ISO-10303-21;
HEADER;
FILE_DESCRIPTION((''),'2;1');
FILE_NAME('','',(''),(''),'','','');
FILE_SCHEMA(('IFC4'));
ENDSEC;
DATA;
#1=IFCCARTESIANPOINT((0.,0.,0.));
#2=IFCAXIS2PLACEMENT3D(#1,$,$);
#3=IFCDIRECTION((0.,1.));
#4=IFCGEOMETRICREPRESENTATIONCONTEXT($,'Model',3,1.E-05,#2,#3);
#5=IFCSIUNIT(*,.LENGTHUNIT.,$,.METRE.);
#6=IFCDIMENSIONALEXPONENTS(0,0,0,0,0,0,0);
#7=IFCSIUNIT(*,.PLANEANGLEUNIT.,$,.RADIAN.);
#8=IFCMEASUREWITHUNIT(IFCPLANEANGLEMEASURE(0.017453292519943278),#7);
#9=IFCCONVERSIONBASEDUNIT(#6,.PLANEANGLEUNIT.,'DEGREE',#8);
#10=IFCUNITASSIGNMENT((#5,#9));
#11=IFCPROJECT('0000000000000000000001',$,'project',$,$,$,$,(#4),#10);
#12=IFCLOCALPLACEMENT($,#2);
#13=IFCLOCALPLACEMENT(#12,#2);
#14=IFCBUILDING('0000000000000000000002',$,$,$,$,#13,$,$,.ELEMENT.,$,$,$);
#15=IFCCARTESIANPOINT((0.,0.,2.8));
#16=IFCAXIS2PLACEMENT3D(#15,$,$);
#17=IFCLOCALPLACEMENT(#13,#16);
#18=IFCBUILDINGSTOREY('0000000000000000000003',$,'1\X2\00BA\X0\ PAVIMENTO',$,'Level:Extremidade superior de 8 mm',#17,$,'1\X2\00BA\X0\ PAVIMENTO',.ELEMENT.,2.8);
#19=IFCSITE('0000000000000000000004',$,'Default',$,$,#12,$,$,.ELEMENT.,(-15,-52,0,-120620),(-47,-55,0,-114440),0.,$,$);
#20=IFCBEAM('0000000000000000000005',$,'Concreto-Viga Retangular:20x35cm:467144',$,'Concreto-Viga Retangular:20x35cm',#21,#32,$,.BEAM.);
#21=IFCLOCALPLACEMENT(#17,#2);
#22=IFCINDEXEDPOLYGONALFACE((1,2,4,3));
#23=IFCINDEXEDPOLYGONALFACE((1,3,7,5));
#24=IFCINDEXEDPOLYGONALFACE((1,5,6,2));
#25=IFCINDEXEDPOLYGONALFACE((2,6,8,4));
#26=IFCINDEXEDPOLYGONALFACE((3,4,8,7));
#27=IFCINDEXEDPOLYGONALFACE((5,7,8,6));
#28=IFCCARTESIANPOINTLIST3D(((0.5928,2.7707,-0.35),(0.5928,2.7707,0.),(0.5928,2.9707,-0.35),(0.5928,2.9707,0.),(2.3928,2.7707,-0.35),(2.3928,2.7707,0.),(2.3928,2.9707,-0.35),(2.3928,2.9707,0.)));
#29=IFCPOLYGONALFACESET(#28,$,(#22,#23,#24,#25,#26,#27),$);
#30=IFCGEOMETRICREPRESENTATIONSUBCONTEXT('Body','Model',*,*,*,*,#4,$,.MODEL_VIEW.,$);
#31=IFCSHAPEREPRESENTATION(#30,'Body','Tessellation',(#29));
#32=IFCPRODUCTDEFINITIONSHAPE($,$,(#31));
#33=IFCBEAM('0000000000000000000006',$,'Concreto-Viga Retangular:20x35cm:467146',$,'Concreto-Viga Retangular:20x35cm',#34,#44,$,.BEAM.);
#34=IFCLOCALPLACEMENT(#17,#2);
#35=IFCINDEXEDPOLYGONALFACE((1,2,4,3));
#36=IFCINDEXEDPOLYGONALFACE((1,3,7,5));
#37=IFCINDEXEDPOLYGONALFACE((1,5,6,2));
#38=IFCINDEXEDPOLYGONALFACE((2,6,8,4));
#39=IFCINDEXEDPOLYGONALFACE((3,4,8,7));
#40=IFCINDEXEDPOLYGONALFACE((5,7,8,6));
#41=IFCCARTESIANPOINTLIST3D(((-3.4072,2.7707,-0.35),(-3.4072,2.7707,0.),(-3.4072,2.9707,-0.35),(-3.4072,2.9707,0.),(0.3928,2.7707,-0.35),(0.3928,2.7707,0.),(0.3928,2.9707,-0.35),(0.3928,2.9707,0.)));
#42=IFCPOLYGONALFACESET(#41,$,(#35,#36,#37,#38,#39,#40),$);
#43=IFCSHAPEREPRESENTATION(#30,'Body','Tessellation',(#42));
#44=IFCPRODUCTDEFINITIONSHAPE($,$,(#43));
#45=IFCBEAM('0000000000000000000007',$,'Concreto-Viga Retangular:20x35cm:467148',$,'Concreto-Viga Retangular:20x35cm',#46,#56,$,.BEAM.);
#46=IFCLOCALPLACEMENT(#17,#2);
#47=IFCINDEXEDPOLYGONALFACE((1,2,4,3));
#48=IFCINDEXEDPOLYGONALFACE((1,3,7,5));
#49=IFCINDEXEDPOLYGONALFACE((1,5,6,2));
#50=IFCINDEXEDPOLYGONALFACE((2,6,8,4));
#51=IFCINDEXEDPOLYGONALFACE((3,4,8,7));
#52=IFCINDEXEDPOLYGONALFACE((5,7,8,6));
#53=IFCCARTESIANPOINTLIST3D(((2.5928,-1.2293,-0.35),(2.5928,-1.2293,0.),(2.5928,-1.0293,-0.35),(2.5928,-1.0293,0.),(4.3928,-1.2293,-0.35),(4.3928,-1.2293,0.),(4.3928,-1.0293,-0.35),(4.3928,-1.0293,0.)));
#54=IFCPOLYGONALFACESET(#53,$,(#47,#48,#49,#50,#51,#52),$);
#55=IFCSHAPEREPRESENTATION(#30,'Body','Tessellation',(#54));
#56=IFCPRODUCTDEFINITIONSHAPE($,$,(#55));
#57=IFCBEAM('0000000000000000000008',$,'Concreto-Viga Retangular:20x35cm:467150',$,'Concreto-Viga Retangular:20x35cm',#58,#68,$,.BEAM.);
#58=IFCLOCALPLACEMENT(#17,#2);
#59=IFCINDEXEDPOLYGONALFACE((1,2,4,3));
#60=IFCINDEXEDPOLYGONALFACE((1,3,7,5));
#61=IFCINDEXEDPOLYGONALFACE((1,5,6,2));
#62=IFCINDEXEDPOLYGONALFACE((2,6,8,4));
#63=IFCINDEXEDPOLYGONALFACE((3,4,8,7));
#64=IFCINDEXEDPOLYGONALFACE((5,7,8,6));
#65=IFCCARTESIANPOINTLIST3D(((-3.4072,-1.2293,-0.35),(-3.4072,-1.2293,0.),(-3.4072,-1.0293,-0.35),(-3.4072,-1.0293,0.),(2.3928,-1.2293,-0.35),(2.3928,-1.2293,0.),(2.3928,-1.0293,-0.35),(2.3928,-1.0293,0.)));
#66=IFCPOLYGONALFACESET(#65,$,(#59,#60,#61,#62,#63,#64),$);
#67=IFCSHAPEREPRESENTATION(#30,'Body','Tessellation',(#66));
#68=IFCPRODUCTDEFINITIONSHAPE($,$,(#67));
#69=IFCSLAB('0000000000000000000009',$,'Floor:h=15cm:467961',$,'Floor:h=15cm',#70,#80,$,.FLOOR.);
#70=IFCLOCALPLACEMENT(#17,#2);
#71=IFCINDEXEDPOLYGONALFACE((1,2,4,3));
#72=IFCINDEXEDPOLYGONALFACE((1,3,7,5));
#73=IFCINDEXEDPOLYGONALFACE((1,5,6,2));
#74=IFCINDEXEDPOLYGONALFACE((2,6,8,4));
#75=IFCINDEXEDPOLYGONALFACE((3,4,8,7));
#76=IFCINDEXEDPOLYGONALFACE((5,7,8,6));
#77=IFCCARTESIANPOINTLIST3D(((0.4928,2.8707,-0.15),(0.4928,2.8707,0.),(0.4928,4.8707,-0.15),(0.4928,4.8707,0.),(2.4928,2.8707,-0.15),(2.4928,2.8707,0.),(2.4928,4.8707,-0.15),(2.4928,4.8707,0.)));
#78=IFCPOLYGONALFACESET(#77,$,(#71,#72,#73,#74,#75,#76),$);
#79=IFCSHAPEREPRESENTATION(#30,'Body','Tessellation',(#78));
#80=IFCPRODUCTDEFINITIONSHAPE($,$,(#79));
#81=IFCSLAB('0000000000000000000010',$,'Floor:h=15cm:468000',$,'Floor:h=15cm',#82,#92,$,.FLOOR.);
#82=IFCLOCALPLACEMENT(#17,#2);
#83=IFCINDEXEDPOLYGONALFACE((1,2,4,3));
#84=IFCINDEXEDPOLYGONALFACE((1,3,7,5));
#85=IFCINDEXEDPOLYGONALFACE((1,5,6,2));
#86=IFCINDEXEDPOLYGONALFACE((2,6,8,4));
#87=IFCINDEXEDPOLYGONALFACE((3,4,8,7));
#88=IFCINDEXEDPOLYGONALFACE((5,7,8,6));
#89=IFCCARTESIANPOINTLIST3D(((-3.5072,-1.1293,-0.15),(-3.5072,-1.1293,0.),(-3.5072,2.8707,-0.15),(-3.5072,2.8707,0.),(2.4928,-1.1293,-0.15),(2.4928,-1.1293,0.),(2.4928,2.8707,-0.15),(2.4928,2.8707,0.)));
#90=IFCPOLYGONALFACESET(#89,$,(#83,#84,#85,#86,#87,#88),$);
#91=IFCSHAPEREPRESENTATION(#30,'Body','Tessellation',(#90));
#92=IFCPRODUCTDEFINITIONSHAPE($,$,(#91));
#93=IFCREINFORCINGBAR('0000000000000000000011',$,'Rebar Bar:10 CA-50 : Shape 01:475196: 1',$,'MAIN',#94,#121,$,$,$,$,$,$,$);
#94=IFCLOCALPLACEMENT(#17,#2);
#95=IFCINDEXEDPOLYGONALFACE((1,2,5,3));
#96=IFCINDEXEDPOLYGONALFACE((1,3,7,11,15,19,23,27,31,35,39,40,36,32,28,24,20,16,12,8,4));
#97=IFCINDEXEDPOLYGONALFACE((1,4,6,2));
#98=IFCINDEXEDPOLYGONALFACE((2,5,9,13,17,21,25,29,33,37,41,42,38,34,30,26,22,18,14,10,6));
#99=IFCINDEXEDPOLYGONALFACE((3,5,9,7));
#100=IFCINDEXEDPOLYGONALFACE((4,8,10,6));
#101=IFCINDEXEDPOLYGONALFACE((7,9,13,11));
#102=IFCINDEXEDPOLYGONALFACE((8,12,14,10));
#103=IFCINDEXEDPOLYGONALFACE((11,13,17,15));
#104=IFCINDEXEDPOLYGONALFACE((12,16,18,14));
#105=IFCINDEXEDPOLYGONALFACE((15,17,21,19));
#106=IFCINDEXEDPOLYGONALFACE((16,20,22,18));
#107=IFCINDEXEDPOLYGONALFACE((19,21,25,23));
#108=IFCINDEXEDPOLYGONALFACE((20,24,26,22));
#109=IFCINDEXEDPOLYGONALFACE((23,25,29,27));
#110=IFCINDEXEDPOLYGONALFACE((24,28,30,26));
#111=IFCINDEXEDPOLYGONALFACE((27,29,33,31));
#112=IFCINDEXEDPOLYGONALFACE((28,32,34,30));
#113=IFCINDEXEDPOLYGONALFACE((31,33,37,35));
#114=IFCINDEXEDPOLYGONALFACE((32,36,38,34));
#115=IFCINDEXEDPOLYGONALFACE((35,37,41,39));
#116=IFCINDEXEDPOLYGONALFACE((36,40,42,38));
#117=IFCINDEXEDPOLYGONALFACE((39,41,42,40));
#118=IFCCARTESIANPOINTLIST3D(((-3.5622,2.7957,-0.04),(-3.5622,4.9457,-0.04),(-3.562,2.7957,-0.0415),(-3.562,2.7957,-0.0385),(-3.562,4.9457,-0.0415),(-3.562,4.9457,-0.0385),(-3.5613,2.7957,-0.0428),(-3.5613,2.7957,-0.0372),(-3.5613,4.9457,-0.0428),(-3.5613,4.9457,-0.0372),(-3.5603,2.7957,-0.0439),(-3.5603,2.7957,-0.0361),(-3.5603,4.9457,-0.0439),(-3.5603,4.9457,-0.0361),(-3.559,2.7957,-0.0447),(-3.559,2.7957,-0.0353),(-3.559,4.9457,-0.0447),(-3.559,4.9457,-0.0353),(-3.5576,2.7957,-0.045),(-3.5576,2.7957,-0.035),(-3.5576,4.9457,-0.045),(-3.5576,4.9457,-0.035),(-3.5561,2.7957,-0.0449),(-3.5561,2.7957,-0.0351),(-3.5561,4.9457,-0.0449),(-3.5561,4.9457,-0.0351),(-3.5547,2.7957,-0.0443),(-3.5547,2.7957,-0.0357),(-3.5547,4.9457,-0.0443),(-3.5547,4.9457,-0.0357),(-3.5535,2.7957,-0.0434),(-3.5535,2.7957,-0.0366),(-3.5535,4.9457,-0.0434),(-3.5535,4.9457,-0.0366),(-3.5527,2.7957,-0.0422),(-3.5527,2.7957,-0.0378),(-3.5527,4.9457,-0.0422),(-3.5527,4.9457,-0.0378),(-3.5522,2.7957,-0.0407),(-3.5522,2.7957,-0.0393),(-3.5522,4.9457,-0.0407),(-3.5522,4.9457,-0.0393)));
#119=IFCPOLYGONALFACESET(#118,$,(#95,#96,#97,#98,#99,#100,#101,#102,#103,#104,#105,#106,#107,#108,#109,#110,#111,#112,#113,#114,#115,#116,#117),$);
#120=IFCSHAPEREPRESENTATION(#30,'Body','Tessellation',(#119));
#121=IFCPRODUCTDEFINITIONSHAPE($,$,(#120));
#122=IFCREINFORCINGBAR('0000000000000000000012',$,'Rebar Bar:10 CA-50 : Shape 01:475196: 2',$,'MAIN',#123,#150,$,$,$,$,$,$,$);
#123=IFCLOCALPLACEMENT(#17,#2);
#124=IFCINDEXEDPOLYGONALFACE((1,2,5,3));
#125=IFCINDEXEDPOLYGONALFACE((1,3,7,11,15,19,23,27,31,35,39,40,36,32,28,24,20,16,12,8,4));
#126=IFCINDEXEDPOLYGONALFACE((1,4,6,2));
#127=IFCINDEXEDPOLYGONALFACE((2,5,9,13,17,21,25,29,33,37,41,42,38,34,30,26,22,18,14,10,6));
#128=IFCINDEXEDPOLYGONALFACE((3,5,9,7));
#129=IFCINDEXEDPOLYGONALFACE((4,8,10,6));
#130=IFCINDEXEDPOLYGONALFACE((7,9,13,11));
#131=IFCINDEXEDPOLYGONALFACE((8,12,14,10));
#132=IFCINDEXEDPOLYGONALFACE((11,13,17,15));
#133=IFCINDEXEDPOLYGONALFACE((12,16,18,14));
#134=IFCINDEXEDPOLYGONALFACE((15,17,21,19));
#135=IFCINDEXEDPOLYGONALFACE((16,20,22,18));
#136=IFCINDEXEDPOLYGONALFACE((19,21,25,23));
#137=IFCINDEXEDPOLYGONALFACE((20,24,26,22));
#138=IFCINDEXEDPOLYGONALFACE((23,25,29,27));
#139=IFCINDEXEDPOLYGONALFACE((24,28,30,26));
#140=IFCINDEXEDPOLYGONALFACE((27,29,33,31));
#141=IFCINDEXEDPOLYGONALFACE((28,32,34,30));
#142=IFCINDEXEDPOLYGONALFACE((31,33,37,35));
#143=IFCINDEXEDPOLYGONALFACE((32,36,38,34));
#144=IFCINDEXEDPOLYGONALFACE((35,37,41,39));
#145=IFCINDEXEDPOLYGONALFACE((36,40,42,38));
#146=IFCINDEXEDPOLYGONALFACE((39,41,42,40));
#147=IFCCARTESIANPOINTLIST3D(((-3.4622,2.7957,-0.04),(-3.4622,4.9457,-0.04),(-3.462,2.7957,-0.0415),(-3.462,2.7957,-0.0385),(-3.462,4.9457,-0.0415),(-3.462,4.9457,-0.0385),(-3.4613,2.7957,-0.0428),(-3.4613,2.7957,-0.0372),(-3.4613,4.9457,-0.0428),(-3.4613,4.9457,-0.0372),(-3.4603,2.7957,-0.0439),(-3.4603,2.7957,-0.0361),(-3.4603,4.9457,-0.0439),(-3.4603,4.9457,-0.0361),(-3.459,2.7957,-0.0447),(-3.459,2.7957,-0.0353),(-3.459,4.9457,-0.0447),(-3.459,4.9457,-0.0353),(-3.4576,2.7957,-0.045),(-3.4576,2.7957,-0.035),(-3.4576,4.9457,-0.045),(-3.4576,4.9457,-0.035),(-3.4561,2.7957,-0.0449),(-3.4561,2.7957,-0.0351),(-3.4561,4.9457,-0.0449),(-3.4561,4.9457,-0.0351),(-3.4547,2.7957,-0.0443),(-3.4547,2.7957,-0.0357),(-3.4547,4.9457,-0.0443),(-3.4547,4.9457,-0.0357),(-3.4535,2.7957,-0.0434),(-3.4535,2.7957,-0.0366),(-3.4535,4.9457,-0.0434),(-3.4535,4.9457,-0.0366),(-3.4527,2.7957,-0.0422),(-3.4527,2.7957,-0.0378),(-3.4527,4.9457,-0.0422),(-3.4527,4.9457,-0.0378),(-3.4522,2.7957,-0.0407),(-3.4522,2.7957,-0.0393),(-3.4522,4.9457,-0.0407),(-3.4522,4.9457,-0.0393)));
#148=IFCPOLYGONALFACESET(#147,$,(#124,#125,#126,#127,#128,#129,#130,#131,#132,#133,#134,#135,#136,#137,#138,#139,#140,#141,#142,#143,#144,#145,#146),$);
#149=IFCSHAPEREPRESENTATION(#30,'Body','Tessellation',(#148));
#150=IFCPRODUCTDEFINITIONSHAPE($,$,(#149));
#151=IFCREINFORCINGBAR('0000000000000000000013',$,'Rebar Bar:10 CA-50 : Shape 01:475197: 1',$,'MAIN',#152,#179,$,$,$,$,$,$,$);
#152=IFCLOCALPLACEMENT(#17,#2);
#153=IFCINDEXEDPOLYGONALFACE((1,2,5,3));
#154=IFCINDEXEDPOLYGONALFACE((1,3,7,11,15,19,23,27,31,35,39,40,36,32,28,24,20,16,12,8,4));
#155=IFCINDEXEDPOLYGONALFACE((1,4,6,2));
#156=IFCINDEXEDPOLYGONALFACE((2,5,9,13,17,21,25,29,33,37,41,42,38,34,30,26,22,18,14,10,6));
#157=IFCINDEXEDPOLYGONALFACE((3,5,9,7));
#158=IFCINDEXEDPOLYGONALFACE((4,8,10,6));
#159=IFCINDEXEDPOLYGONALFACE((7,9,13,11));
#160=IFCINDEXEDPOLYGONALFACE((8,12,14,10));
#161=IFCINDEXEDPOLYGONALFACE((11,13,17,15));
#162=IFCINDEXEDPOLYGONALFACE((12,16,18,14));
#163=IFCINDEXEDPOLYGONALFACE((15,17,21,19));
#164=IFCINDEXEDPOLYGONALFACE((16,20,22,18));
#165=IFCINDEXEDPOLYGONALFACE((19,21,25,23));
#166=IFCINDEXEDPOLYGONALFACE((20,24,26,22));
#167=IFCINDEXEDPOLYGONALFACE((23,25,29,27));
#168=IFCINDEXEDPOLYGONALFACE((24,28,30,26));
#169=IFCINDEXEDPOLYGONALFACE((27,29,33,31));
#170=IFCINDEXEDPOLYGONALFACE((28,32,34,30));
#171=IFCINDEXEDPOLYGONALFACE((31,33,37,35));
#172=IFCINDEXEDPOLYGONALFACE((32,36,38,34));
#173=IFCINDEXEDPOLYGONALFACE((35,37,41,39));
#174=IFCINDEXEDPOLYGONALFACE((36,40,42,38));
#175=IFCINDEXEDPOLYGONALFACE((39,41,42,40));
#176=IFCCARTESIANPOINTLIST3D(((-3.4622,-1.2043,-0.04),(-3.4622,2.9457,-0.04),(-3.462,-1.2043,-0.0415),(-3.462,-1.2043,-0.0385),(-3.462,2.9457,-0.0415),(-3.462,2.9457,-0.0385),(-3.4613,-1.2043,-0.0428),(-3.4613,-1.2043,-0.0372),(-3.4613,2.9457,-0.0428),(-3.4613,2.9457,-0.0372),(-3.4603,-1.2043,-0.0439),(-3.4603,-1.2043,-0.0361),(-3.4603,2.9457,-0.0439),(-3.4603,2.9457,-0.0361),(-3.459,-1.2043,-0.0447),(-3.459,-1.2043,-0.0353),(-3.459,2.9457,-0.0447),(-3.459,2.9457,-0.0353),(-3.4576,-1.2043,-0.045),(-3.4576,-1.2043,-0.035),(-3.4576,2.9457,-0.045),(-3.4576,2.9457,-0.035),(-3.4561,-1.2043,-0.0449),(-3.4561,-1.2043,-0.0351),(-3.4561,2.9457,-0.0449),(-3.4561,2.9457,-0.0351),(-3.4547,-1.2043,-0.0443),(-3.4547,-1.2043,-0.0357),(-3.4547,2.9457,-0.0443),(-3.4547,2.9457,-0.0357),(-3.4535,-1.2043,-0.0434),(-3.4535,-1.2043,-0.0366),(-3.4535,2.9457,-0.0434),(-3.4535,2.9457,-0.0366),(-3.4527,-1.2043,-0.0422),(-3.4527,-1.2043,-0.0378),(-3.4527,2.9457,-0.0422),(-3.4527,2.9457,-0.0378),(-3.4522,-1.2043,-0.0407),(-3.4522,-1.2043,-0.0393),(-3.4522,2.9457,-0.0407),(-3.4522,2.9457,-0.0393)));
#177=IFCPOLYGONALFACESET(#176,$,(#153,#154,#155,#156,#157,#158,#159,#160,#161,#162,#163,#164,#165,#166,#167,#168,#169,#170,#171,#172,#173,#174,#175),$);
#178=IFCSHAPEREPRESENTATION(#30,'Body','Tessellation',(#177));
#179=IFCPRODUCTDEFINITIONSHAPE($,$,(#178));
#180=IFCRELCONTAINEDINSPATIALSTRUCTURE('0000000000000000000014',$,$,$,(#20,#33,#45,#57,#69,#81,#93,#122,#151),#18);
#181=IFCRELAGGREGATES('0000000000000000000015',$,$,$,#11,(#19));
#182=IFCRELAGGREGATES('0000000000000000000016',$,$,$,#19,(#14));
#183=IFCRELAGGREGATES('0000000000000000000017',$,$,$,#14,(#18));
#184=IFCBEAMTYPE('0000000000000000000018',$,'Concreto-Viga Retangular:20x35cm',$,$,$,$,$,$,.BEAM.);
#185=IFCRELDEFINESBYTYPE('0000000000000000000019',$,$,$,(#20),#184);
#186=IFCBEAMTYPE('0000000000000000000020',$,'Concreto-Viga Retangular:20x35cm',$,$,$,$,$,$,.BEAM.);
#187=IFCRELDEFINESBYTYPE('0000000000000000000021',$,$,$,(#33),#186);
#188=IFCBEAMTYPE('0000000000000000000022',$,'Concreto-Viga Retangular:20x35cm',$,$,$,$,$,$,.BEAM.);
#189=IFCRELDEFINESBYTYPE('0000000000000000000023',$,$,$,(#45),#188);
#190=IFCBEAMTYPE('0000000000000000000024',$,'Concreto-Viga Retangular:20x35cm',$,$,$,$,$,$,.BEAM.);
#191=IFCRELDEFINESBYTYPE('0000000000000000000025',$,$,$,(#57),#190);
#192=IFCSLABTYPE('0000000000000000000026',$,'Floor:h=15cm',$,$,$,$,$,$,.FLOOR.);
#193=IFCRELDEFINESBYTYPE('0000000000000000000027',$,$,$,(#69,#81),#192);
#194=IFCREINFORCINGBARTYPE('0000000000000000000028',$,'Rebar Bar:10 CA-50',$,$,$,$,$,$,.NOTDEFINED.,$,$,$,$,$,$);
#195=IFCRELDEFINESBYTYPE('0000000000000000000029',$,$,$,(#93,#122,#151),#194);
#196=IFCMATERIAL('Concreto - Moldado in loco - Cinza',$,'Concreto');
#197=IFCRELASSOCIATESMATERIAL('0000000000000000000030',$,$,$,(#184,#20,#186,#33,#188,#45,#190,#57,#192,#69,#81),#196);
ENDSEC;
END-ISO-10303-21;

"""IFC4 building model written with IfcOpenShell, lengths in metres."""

from ifc_helpers import new_model, entity, si_unit, converted_unit, direction, frame, origin, place, context, subcontext, project, spatial, indexed_curve, outline, extrude, source, transform, mapped, material, type_object, type_shapes, element, save


model = new_model("IFC4")

# Units and contexts
model_context = context("Model", 3, precision=1e-05, world=origin(), true_north=direction((0.0, 1.0)))
body_context = subcontext(model_context, "Body", "Model", "MODEL_VIEW")
ifc_project = project(units=[si_unit("LENGTHUNIT", "METRE"), converted_unit("PLANEANGLEUNIT", "DEGREE", entity("IfcPlaneAngleMeasure", 0.017453292519943278), si_unit("PLANEANGLEUNIT", "RADIAN"), dimensions=[0, 0, 0, 0, 0, 0, 0])], contexts=[model_context])

# Site, building, storey
site_placement = place(None, origin())
site = spatial("IfcSite", under=ifc_project, at=site_placement, Name="Default", CompositionType="ELEMENT", RefLatitude=(-15, -52, 0, -120620), RefLongitude=(-47, -55, 0, -114440), RefElevation=0.0)
building_placement = place(site_placement, origin())
building = spatial("IfcBuilding", under=site, at=building_placement, CompositionType="ELEMENT")
storey_placement = place(building_placement, frame((0.0, 0.0, 2.8)))
storey = spatial("IfcBuildingStorey", under=building, at=storey_placement, Name="1º PAVIMENTO", ObjectType="Level:Extremidade superior de 8 mm", LongName="1º PAVIMENTO", CompositionType="ELEMENT", Elevation=2.8)

# Beams
ifc_material = material(Name="Concreto - Moldado in loco - Cinza", Category="Concreto")
beam_type_1 = type_object("IfcBeamType", Name="Concreto-Viga Retangular:20x35cm", PredefinedType="BEAM", material=ifc_material)
shared_shape_1 = source(origin(), body_context, "Body", "SweptSolid", [
    extrude(outline(indexed_curve([(-0.175, -0.1), (0.175, -0.1), (0.175, 0.1), (-0.175, 0.1), (-0.175, -0.1)], self_intersect=False)), frame((2.3928, 2.8707, 2.625), z_axis=(-1.0, 0.0, 0.0), x_axis=(0.0, 0.0, -1.0)), (0.0, 0.0, 1.0), 1.8),
])
type_shapes(beam_type_1, [shared_shape_1])
beam_1_placement = place(storey_placement, frame((0.0, 0.0, -2.8)))
element("IfcBeam", 1, at=beam_1_placement, inside=storey, type_object=beam_type_1, material=ifc_material, Name="Concreto-Viga Retangular:20x35cm:467144", ObjectType="Concreto-Viga Retangular:20x35cm", PredefinedType="BEAM", context=body_context, shape_type="MappedRepresentation", body=[
    mapped(shared_shape_1, transform((0.0, 0.0, 0.0), scale=1.0)),
])
beam_type_2 = type_object("IfcBeamType", Name="Concreto-Viga Retangular:20x35cm", PredefinedType="BEAM", material=ifc_material)
shared_shape_2 = source(origin(), body_context, "Body", "SweptSolid", [
    extrude(outline(indexed_curve([(-0.175, -0.1), (0.175, -0.1), (0.175, 0.1), (-0.175, 0.1), (-0.175, -0.1)], self_intersect=False)), frame((0.3928, 2.8707, 2.625), z_axis=(-1.0, 0.0, 0.0), x_axis=(0.0, 0.0, -1.0)), (0.0, 0.0, 1.0), 3.8),
])
type_shapes(beam_type_2, [shared_shape_2])
beam_2_placement = place(storey_placement, frame((0.0, 0.0, -2.8)))
element("IfcBeam", 2, at=beam_2_placement, inside=storey, type_object=beam_type_2, material=ifc_material, Name="Concreto-Viga Retangular:20x35cm:467146", ObjectType="Concreto-Viga Retangular:20x35cm", PredefinedType="BEAM", context=body_context, shape_type="MappedRepresentation", body=[
    mapped(shared_shape_2, transform((0.0, 0.0, 0.0), scale=1.0)),
])
beam_type_3 = type_object("IfcBeamType", Name="Concreto-Viga Retangular:20x35cm", PredefinedType="BEAM", material=ifc_material)
shared_shape_3 = source(origin(), body_context, "Body", "SweptSolid", [
    extrude(outline(indexed_curve([(-0.175, -0.1), (0.175, -0.1), (0.175, 0.1), (-0.175, 0.1), (-0.175, -0.1)], self_intersect=False)), frame((4.3928, -1.1293, 2.625), z_axis=(-1.0, 0.0, 0.0), x_axis=(0.0, 0.0, -1.0)), (0.0, 0.0, 1.0), 1.8),
])
type_shapes(beam_type_3, [shared_shape_3])
beam_3_placement = place(storey_placement, frame((0.0, 0.0, -2.8)))
element("IfcBeam", 3, at=beam_3_placement, inside=storey, type_object=beam_type_3, material=ifc_material, Name="Concreto-Viga Retangular:20x35cm:467148", ObjectType="Concreto-Viga Retangular:20x35cm", PredefinedType="BEAM", context=body_context, shape_type="MappedRepresentation", body=[
    mapped(shared_shape_3, transform((0.0, 0.0, 0.0), scale=1.0)),
])
beam_type_4 = type_object("IfcBeamType", Name="Concreto-Viga Retangular:20x35cm", PredefinedType="BEAM", material=ifc_material)
shared_shape_4 = source(origin(), body_context, "Body", "SweptSolid", [
    extrude(outline(indexed_curve([(-0.175, -0.1), (0.175, -0.1), (0.175, 0.1), (-0.175, 0.1), (-0.175, -0.1)], self_intersect=False)), frame((2.3928, -1.1293, 2.625), z_axis=(-1.0, 0.0, 0.0), x_axis=(0.0, 0.0, -1.0)), (0.0, 0.0, 1.0), 5.8),
])
type_shapes(beam_type_4, [shared_shape_4])
beam_4_placement = place(storey_placement, frame((0.0, 0.0, -2.8)))
element("IfcBeam", 4, at=beam_4_placement, inside=storey, type_object=beam_type_4, material=ifc_material, Name="Concreto-Viga Retangular:20x35cm:467150", ObjectType="Concreto-Viga Retangular:20x35cm", PredefinedType="BEAM", context=body_context, shape_type="MappedRepresentation", body=[
    mapped(shared_shape_4, transform((0.0, 0.0, 0.0), scale=1.0)),
])

# Slabs
slab_type = type_object("IfcSlabType", Name="Floor:h=15cm", PredefinedType="FLOOR", material=ifc_material)
slab_1_placement = place(storey_placement, origin())
element("IfcSlab", 5, at=slab_1_placement, inside=storey, type_object=slab_type, material=ifc_material, Name="Floor:h=15cm:467961", ObjectType="Floor:h=15cm", PredefinedType="FLOOR", context=body_context, shape_type="SweptSolid", body=[
    extrude(outline(indexed_curve([(-1.0, -1.0), (1.0, -1.0), (1.0, 1.0), (-1.0, 1.0), (-1.0, -1.0)], self_intersect=False)), frame((1.4928, 3.8707, 0.0), z_axis=(0.0, 0.0, -1.0), x_axis=(0.0, 1.0, 0.0)), (0.0, 0.0, 1.0), 0.15),
])
slab_2_placement = place(storey_placement, origin())
element("IfcSlab", 6, at=slab_2_placement, inside=storey, type_object=slab_type, material=ifc_material, Name="Floor:h=15cm:468000", ObjectType="Floor:h=15cm", PredefinedType="FLOOR", context=body_context, shape_type="SweptSolid", body=[
    extrude(outline(indexed_curve([(-2.0, -3.0), (2.0, -3.0), (2.0, 3.0), (-2.0, 3.0), (-2.0, -3.0)], self_intersect=False)), frame((-0.5072, 0.8707, 0.0), z_axis=(0.0, 0.0, -1.0), x_axis=(0.0, 1.0, 0.0)), (0.0, 0.0, 1.0), 0.15),
])

# Reinforcing bars
reinforcing_bar_type = type_object("IfcReinforcingBarType", Name="Rebar Bar:10 CA-50", PredefinedType="NOTDEFINED")
reinforcing_bar_1_placement = place(storey_placement, origin())
element("IfcReinforcingBar", 7, at=reinforcing_bar_1_placement, inside=storey, type_object=reinforcing_bar_type, Name="Rebar Bar:10 CA-50 : Shape 01:475196: 1", ObjectType="MAIN", context=body_context, shape_type="AdvancedSweptSolid", body=[
    entity("IfcSweptDiskSolid", entity("IfcIndexedPolyCurve", entity("IfcCartesianPointList3D", [[-3.5572, 4.9457, -0.04], [-3.5572, 2.7957, -0.04]]), None, False), 0.005, None, 0.0, 1.0),
])
reinforcing_bar_2_placement = place(storey_placement, origin())
element("IfcReinforcingBar", 8, at=reinforcing_bar_2_placement, inside=storey, type_object=reinforcing_bar_type, Name="Rebar Bar:10 CA-50 : Shape 01:475196: 2", ObjectType="MAIN", context=body_context, shape_type="AdvancedSweptSolid", body=[
    entity("IfcSweptDiskSolid", entity("IfcIndexedPolyCurve", entity("IfcCartesianPointList3D", [[-3.4572, 4.9457, -0.04], [-3.4572, 2.7957, -0.04]]), None, False), 0.005, None, 0.0, 1.0),
])
reinforcing_bar_3_placement = place(storey_placement, origin())
element("IfcReinforcingBar", 9, at=reinforcing_bar_3_placement, inside=storey, type_object=reinforcing_bar_type, Name="Rebar Bar:10 CA-50 : Shape 01:475197: 1", ObjectType="MAIN", context=body_context, shape_type="AdvancedSweptSolid", body=[
    entity("IfcSweptDiskSolid", entity("IfcIndexedPolyCurve", entity("IfcCartesianPointList3D", [[-3.4572, 2.9457, -0.04], [-3.4572, -1.2043, -0.04]]), None, False), 0.005, None, 0.0, 1.0),
])

save(model, "model.ifc")
